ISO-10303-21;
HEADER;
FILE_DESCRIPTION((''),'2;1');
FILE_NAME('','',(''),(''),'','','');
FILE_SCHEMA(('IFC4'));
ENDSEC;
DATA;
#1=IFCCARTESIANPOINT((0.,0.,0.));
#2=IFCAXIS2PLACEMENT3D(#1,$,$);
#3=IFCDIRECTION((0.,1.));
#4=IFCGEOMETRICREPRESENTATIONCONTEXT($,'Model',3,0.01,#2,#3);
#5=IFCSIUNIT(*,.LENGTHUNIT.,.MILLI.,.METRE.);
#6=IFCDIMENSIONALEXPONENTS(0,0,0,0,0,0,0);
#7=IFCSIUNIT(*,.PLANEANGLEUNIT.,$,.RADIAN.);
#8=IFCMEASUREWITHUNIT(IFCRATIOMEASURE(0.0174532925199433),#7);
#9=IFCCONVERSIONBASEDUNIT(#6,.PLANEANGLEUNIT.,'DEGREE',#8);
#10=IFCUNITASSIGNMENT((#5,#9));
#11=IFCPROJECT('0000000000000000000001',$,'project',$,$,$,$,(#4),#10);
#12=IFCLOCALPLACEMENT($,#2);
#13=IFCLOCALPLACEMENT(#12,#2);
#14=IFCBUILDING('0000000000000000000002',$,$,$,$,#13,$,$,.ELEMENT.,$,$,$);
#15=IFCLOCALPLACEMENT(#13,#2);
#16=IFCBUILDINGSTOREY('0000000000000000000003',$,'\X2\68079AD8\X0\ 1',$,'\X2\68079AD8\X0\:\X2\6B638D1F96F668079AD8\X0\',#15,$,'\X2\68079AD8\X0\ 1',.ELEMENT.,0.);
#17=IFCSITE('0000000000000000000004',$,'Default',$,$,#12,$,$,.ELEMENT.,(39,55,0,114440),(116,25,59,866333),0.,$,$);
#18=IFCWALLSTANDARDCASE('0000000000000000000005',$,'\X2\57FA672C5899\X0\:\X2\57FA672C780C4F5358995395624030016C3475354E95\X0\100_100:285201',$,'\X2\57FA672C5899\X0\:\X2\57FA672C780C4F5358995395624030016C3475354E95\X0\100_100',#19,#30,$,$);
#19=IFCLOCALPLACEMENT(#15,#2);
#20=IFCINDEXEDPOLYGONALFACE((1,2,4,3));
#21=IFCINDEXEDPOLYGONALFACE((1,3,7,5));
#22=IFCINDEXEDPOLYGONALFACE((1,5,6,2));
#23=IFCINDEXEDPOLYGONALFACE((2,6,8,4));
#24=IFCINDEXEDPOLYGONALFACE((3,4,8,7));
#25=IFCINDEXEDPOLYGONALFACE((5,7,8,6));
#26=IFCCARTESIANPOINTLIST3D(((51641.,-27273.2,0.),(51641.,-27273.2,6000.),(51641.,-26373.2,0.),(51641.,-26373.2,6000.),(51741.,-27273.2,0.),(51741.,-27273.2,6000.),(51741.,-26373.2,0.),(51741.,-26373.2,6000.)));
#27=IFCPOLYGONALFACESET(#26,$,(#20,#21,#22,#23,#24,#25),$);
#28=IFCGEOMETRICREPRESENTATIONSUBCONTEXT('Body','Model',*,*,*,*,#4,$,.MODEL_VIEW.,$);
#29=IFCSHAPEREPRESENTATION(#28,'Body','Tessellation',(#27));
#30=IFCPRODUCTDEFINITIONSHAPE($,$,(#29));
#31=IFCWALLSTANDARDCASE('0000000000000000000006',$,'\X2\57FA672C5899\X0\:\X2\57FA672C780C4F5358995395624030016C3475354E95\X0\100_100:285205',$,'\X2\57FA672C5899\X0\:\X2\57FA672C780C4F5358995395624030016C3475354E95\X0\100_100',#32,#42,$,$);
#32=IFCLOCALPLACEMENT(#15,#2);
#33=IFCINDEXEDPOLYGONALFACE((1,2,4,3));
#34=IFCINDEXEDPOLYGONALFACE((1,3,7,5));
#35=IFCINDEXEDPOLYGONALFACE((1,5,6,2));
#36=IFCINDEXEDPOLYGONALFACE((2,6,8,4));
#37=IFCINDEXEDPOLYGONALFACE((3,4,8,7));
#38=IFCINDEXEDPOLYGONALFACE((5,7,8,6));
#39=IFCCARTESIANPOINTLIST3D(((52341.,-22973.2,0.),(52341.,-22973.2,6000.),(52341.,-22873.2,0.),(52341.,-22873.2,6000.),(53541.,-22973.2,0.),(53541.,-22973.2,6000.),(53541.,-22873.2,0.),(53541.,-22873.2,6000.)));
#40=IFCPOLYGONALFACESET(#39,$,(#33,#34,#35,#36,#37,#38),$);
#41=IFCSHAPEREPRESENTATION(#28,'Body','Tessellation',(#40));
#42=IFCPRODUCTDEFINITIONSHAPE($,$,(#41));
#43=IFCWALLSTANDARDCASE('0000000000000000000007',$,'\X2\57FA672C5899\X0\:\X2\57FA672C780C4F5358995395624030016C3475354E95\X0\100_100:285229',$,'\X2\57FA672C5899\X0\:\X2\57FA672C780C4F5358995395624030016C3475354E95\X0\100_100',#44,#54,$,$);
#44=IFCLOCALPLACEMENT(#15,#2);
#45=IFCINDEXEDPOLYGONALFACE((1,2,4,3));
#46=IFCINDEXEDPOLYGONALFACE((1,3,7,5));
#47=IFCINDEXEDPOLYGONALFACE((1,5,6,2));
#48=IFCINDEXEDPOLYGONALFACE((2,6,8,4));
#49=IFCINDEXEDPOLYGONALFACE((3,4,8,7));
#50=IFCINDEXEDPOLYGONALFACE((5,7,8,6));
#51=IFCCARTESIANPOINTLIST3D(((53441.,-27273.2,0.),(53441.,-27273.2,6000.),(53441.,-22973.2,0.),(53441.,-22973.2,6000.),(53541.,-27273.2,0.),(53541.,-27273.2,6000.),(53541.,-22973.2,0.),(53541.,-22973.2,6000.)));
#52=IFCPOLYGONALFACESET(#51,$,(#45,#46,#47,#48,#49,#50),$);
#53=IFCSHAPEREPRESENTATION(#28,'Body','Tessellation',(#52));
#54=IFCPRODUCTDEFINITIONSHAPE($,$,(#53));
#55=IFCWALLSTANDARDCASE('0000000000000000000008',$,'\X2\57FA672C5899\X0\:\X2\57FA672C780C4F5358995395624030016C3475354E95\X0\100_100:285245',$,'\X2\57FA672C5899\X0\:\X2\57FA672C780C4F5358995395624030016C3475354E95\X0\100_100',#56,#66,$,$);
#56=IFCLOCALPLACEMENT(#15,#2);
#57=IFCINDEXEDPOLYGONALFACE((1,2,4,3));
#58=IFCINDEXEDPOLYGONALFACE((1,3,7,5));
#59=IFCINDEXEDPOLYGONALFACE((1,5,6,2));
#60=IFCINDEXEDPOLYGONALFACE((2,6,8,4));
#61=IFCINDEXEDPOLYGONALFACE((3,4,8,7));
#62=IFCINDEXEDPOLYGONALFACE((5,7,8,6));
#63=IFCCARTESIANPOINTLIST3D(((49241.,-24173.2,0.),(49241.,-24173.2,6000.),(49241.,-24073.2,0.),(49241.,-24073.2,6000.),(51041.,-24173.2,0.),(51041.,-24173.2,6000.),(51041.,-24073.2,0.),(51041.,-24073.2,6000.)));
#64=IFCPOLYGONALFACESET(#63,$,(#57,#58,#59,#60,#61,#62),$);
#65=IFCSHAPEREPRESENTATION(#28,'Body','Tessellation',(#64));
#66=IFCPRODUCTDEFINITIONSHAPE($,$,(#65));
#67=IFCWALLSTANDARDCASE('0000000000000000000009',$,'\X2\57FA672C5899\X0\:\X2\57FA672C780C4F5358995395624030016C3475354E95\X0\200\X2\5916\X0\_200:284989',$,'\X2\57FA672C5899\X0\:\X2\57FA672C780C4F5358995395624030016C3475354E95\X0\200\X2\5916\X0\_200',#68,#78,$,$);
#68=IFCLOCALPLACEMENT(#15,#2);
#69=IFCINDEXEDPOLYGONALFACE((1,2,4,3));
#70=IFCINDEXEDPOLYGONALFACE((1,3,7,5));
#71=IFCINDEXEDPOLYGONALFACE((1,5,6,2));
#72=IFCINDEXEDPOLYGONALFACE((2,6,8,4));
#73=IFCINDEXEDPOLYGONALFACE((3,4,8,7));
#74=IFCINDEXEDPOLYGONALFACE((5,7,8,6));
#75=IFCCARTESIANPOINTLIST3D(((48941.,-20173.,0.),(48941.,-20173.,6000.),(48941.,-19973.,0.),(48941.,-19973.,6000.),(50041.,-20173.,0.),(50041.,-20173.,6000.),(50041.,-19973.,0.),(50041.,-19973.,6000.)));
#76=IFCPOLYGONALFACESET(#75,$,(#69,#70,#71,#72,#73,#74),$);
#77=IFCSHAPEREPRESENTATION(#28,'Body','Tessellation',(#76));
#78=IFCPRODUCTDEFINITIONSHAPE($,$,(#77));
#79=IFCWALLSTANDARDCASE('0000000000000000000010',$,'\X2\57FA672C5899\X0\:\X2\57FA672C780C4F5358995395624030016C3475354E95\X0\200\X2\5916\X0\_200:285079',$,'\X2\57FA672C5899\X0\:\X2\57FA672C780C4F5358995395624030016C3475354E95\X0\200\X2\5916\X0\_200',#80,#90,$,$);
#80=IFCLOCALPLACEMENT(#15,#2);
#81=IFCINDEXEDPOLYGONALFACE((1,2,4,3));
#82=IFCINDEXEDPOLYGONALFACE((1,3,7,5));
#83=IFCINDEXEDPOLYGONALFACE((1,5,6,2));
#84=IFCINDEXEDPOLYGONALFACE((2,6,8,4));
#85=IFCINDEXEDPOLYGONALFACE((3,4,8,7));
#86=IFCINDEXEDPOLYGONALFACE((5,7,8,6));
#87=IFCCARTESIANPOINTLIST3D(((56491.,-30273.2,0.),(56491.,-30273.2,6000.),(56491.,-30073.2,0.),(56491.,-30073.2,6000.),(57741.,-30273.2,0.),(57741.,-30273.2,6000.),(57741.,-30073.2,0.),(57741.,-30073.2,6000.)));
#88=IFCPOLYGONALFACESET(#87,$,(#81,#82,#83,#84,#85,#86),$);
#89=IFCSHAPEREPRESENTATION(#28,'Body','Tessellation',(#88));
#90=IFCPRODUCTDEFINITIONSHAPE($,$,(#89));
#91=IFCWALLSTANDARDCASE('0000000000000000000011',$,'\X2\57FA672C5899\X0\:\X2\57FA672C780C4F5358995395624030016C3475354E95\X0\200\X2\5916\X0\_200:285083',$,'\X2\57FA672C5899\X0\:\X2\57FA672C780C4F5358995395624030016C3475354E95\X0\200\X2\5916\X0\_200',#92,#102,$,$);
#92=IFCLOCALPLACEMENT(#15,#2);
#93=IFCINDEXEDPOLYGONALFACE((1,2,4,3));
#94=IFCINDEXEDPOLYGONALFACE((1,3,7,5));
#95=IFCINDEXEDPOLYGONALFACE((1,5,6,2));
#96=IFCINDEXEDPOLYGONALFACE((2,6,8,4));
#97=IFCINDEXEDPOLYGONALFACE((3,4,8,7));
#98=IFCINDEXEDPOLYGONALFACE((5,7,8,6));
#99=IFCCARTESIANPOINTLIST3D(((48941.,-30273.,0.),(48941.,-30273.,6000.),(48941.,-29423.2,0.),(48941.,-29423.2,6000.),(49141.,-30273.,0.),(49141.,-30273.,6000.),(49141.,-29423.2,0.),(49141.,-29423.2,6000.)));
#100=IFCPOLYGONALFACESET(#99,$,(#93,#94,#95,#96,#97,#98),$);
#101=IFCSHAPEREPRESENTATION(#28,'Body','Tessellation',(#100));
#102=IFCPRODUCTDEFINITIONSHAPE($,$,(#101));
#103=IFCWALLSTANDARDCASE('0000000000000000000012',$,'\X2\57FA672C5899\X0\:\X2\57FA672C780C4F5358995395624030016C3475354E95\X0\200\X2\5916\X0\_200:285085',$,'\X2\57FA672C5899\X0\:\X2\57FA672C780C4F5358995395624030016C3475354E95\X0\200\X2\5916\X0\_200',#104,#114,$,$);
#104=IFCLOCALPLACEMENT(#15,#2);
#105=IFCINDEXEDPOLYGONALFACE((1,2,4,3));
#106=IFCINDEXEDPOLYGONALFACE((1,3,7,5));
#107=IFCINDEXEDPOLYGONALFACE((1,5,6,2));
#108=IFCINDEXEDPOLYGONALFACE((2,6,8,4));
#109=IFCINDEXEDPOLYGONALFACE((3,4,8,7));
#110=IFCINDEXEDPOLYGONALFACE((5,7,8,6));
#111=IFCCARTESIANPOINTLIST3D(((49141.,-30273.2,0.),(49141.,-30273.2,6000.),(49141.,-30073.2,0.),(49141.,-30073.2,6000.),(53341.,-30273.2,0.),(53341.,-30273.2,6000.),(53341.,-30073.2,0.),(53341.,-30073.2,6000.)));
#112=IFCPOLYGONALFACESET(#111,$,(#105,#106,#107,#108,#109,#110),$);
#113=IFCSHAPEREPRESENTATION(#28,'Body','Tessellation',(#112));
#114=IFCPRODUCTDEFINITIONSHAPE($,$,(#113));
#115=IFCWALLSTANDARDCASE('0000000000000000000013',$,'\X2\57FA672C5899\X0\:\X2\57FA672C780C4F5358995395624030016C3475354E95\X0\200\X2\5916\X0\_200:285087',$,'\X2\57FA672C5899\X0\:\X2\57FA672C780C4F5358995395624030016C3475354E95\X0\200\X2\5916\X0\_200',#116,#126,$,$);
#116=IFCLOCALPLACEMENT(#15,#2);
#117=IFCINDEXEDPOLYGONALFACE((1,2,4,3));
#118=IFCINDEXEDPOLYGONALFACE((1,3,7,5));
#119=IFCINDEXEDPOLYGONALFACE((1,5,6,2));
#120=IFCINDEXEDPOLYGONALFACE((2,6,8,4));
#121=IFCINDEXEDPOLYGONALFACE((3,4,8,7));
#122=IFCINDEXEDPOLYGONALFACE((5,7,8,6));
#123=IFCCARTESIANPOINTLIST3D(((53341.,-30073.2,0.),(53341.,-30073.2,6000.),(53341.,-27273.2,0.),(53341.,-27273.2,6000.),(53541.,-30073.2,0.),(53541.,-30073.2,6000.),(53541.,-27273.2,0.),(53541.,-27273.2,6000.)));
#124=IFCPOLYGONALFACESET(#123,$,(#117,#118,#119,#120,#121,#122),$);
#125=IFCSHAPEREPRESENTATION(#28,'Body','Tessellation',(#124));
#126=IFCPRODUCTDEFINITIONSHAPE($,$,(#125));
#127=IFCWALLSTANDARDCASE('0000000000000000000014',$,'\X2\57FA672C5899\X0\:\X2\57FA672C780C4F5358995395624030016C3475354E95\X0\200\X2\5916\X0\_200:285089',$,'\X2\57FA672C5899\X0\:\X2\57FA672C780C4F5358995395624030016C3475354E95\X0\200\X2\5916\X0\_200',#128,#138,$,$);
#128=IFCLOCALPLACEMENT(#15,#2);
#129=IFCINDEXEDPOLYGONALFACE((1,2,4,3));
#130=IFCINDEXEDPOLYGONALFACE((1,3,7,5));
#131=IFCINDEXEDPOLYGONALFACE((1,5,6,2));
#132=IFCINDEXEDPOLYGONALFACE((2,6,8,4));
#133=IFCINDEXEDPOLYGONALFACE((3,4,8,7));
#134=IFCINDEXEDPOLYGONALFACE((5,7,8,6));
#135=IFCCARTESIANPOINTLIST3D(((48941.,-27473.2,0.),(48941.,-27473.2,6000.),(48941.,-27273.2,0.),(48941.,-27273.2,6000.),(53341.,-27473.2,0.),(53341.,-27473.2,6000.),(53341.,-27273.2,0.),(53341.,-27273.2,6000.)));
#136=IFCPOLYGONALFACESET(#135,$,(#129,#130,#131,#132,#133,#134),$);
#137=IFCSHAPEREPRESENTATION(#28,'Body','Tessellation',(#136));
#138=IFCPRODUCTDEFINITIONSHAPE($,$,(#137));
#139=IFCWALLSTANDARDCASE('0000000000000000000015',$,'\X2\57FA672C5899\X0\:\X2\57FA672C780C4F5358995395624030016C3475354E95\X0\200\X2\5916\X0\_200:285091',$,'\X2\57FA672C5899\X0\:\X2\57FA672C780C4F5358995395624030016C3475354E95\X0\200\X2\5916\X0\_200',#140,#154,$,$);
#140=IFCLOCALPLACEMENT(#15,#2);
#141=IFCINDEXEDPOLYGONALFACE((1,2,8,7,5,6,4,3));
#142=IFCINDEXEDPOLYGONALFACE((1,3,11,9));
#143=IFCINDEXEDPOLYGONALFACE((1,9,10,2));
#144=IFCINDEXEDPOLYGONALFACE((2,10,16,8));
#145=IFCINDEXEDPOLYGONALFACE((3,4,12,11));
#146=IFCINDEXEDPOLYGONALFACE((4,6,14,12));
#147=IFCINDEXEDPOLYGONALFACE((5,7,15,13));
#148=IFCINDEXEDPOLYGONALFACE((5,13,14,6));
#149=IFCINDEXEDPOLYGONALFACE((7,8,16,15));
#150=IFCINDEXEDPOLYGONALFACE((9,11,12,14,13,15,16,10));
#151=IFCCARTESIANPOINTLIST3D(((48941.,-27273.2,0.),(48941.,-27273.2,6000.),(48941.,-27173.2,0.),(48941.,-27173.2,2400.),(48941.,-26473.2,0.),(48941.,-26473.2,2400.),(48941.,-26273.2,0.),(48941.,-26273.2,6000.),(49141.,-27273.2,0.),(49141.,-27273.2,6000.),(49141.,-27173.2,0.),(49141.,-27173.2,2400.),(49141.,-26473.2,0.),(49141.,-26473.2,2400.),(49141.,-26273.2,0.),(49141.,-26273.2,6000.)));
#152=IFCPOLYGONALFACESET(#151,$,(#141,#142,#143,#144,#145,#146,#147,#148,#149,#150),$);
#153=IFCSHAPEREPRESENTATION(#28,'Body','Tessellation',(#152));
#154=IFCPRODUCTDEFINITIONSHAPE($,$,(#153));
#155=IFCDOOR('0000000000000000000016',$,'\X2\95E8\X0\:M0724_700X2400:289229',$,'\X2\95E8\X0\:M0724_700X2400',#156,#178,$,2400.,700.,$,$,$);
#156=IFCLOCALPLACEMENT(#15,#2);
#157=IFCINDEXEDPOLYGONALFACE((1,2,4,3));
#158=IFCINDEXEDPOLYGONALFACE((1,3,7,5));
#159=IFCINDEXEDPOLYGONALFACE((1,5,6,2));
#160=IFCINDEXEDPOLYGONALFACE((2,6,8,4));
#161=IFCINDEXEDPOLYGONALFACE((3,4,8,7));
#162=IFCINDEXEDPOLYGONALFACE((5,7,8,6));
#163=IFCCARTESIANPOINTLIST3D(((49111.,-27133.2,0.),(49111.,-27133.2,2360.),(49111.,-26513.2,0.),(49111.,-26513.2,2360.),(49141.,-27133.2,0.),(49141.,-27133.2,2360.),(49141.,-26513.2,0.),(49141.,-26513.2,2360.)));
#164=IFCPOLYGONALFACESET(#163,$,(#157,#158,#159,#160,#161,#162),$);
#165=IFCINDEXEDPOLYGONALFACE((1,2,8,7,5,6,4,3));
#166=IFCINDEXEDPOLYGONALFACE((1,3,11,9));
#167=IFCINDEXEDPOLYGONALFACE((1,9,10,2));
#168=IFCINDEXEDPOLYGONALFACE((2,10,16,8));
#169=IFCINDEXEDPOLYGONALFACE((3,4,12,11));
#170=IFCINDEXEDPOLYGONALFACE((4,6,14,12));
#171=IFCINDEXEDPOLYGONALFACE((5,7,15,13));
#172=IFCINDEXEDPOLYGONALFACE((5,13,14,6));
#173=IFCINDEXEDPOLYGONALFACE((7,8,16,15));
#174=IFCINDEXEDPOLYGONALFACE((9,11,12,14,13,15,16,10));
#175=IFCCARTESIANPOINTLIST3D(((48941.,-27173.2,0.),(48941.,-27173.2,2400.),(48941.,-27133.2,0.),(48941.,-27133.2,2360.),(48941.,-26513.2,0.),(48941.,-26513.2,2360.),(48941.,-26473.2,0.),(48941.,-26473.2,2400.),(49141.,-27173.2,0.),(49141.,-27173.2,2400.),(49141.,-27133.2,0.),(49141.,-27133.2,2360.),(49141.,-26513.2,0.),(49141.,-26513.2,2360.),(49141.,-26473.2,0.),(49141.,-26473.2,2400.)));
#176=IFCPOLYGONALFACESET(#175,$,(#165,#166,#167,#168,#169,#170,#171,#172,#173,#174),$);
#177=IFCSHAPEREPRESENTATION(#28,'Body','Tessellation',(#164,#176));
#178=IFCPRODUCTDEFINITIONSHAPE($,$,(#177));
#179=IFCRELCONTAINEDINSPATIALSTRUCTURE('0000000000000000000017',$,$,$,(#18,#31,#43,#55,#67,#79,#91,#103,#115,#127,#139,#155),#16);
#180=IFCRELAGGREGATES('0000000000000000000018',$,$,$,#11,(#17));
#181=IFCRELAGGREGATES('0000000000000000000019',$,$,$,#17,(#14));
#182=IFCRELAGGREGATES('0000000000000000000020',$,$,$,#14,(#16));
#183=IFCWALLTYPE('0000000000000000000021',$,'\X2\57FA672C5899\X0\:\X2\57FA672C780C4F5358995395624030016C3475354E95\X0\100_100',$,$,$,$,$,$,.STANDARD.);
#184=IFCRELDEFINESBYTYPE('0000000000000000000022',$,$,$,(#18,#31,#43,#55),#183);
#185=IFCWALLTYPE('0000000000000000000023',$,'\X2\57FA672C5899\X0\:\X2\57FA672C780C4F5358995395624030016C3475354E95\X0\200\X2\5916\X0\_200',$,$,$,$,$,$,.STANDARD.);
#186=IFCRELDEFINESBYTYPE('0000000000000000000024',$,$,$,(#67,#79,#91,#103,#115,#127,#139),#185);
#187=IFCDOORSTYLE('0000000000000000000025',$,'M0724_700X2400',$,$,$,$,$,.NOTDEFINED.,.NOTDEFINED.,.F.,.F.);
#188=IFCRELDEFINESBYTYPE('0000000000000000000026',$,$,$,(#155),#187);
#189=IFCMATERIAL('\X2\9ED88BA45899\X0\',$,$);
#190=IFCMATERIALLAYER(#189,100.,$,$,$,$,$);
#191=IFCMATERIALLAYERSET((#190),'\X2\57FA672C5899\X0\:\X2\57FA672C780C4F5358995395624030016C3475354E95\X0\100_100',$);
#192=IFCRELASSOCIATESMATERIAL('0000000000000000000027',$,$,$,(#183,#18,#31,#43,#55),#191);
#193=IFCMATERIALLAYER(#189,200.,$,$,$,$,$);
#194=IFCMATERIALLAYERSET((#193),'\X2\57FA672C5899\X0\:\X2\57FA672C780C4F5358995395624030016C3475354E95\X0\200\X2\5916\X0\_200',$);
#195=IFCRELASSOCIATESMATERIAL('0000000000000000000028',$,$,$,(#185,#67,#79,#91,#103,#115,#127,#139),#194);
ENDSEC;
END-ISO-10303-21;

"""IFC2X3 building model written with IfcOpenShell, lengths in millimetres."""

from ifc_helpers import new_model, entity, si_unit, converted_unit, direction, frame, frame_2d, origin, place, context, subcontext, project, spatial, polyline, rectangle, outline, extrude, source, transform, mapped, material, layer, layer_set, layer_usage, type_object, type_shapes, element, fill, save


model = new_model("IFC2X3")

# Units and contexts
model_context = context("Model", 3, precision=0.01, world=origin(), true_north=direction((0.0, 1.0)))
body_context = subcontext(model_context, "Body", "Model", "MODEL_VIEW")
ifc_project = project(units=[si_unit("LENGTHUNIT", "METRE", prefix="MILLI"), converted_unit("PLANEANGLEUNIT", "DEGREE", entity("IfcRatioMeasure", 0.0174532925199433), si_unit("PLANEANGLEUNIT", "RADIAN"), dimensions=[0, 0, 0, 0, 0, 0, 0])], contexts=[model_context])

# Site, building, storey
site_placement = place(None, origin())
site = spatial("IfcSite", under=ifc_project, at=site_placement, Name="Default", CompositionType="ELEMENT", RefLatitude=(39, 55, 0, 114440), RefLongitude=(116, 25, 59, 866333), RefElevation=0.0)
building_placement = place(site_placement, origin())
building = spatial("IfcBuilding", under=site, at=building_placement, CompositionType="ELEMENT")
storey_placement = place(building_placement, origin())
storey = spatial("IfcBuildingStorey", under=building, at=storey_placement, Name="标高 1", ObjectType="标高:正负零标高", LongName="标高 1", CompositionType="ELEMENT", Elevation=0.0)

# Walls
ifc_material = material(Name="默认墙")
ifc_layer_1 = layer(ifc_material, 100.0)
ifc_layer_set_1 = layer_set([ifc_layer_1], Name="基本墙:基本砌体墙厕所、水电井100_100")
wall_type_1 = type_object("IfcWallType", Name="基本墙:基本砌体墙厕所、水电井100_100", PredefinedType="STANDARD", material=ifc_layer_set_1)
ifc_layer_usage_1 = layer_usage(ifc_layer_set_1, "AXIS2", "NEGATIVE", 50.0)
wall_1_placement = place(building_placement, frame((51691.0, -26373.2, 0.0), z_axis=(0.0, 0.0, 1.0), x_axis=(0.0, -1.0, 0.0)))
element("IfcWallStandardCase", 1, at=wall_1_placement, inside=storey, type_object=wall_type_1, material=ifc_layer_usage_1, Name="基本墙:基本砌体墙厕所、水电井100_100:285201", ObjectType="基本墙:基本砌体墙厕所、水电井100_100", context=body_context, shape_type="SweptSolid", body=[
    extrude(rectangle(XDim=900.0, YDim=100.0, at=frame_2d((450.0, 0.0), x_axis=(-1.0, 0.0))), origin(), (0.0, 0.0, 1.0), 6000.0),
])
ifc_layer_usage_2 = layer_usage(ifc_layer_set_1, "AXIS2", "NEGATIVE", 50.0)
wall_2_placement = place(building_placement, frame((52341.0, -22923.2, 0.0)))
element("IfcWallStandardCase", 2, at=wall_2_placement, inside=storey, type_object=wall_type_1, material=ifc_layer_usage_2, Name="基本墙:基本砌体墙厕所、水电井100_100:285205", ObjectType="基本墙:基本砌体墙厕所、水电井100_100", context=body_context, shape_type="SweptSolid", body=[
    extrude(rectangle(XDim=1200.0, YDim=100.0, at=frame_2d((600.0, 0.0), x_axis=(-1.0, 0.0))), origin(), (0.0, 0.0, 1.0), 6000.0),
])
ifc_layer_usage_3 = layer_usage(ifc_layer_set_1, "AXIS2", "NEGATIVE", 50.0)
wall_3_placement = place(building_placement, frame((53491.0, -27273.2, 0.0), z_axis=(0.0, 0.0, 1.0), x_axis=(0.0, 1.0, 0.0)))
element("IfcWallStandardCase", 3, at=wall_3_placement, inside=storey, type_object=wall_type_1, material=ifc_layer_usage_3, Name="基本墙:基本砌体墙厕所、水电井100_100:285229", ObjectType="基本墙:基本砌体墙厕所、水电井100_100", context=body_context, shape_type="SweptSolid", body=[
    extrude(rectangle(XDim=4300.0, YDim=100.0, at=frame_2d((2150.0, 0.0), x_axis=(-1.0, 0.0))), origin(), (0.0, 0.0, 1.0), 6000.0),
])
ifc_layer_usage_4 = layer_usage(ifc_layer_set_1, "AXIS2", "NEGATIVE", 50.0)
wall_4_placement = place(building_placement, frame((51041.0, -24123.2, 0.0), z_axis=(0.0, 0.0, 1.0), x_axis=(-1.0, 0.0, 0.0)))
element("IfcWallStandardCase", 4, at=wall_4_placement, inside=storey, type_object=wall_type_1, material=ifc_layer_usage_4, Name="基本墙:基本砌体墙厕所、水电井100_100:285245", ObjectType="基本墙:基本砌体墙厕所、水电井100_100", context=body_context, shape_type="SweptSolid", body=[
    extrude(rectangle(XDim=1800.0, YDim=100.0, at=frame_2d((900.0, 0.0), x_axis=(-1.0, 0.0))), origin(), (0.0, 0.0, 1.0), 6000.0),
])
ifc_layer_2 = layer(ifc_material, 200.0)
ifc_layer_set_2 = layer_set([ifc_layer_2], Name="基本墙:基本砌体墙厕所、水电井200外_200")
ifc_layer_usage_5 = layer_usage(ifc_layer_set_2, "AXIS2", "NEGATIVE", 100.0)
wall_type_2 = type_object("IfcWallType", Name="基本墙:基本砌体墙厕所、水电井200外_200", PredefinedType="STANDARD", material=ifc_layer_set_2)
wall_5_placement = place(building_placement, frame((48941.0, -20073.0, 0.0)))
element("IfcWallStandardCase", 5, at=wall_5_placement, inside=storey, type_object=wall_type_2, material=ifc_layer_usage_5, Name="基本墙:基本砌体墙厕所、水电井200外_200:284989", ObjectType="基本墙:基本砌体墙厕所、水电井200外_200", context=body_context, shape_type="SweptSolid", body=[
    extrude(rectangle(XDim=1100.0, YDim=200.0, at=frame_2d((550.0, 0.0), x_axis=(-1.0, 0.0))), origin(), (0.0, 0.0, 1.0), 6000.0),
])
ifc_layer_usage_6 = layer_usage(ifc_layer_set_2, "AXIS2", "NEGATIVE", 100.0)
wall_6_placement = place(building_placement, frame((56491.0, -30173.2, 0.0)))
element("IfcWallStandardCase", 6, at=wall_6_placement, inside=storey, type_object=wall_type_2, material=ifc_layer_usage_6, Name="基本墙:基本砌体墙厕所、水电井200外_200:285079", ObjectType="基本墙:基本砌体墙厕所、水电井200外_200", context=body_context, shape_type="SweptSolid", body=[
    extrude(rectangle(XDim=1250.0, YDim=200.0, at=frame_2d((625.0, 0.0), x_axis=(-1.0, 0.0))), origin(), (0.0, 0.0, 1.0), 6000.0),
])
ifc_layer_usage_7 = layer_usage(ifc_layer_set_2, "AXIS2", "NEGATIVE", 100.0)
wall_7_placement = place(building_placement, frame((49041.0, -30273.0, 0.0), z_axis=(0.0, 0.0, 1.0), x_axis=(0.0, 1.0, 0.0)))
element("IfcWallStandardCase", 7, at=wall_7_placement, inside=storey, type_object=wall_type_2, material=ifc_layer_usage_7, Name="基本墙:基本砌体墙厕所、水电井200外_200:285083", ObjectType="基本墙:基本砌体墙厕所、水电井200外_200", context=body_context, shape_type="SweptSolid", body=[
    extrude(rectangle(XDim=849.8, YDim=200.0, at=frame_2d((424.9, 0.0), x_axis=(-1.0, 0.0))), origin(), (0.0, 0.0, 1.0), 6000.0),
])
ifc_layer_usage_8 = layer_usage(ifc_layer_set_2, "AXIS2", "NEGATIVE", 100.0)
wall_8_placement = place(building_placement, frame((53341.0, -30173.2, 0.0), z_axis=(0.0, 0.0, 1.0), x_axis=(-1.0, 0.0, 0.0)))
element("IfcWallStandardCase", 8, at=wall_8_placement, inside=storey, type_object=wall_type_2, material=ifc_layer_usage_8, Name="基本墙:基本砌体墙厕所、水电井200外_200:285085", ObjectType="基本墙:基本砌体墙厕所、水电井200外_200", context=body_context, shape_type="SweptSolid", body=[
    extrude(rectangle(XDim=4200.0, YDim=200.0, at=frame_2d((2100.0, 0.0), x_axis=(-1.0, 0.0))), origin(), (0.0, 0.0, 1.0), 6000.0),
])
ifc_layer_usage_9 = layer_usage(ifc_layer_set_2, "AXIS2", "NEGATIVE", 100.0)
wall_9_placement = place(building_placement, frame((53441.0, -27273.2, 0.0), z_axis=(0.0, 0.0, 1.0), x_axis=(0.0, -1.0, 0.0)))
element("IfcWallStandardCase", 9, at=wall_9_placement, inside=storey, type_object=wall_type_2, material=ifc_layer_usage_9, Name="基本墙:基本砌体墙厕所、水电井200外_200:285087", ObjectType="基本墙:基本砌体墙厕所、水电井200外_200", context=body_context, shape_type="SweptSolid", body=[
    extrude(rectangle(XDim=2800.0, YDim=200.0, at=frame_2d((1400.0, 0.0), x_axis=(-1.0, 0.0))), origin(), (0.0, 0.0, 1.0), 6000.0),
])
ifc_layer_usage_10 = layer_usage(ifc_layer_set_2, "AXIS2", "NEGATIVE", 100.0)
wall_10_placement = place(building_placement, frame((48941.0, -27373.2, 0.0)))
element("IfcWallStandardCase", 10, at=wall_10_placement, inside=storey, type_object=wall_type_2, material=ifc_layer_usage_10, Name="基本墙:基本砌体墙厕所、水电井200外_200:285089", ObjectType="基本墙:基本砌体墙厕所、水电井200外_200", context=body_context, shape_type="SweptSolid", body=[
    extrude(rectangle(XDim=4400.0, YDim=200.0, at=frame_2d((2200.0, 0.0), x_axis=(-1.0, 0.0))), origin(), (0.0, 0.0, 1.0), 6000.0),
])

# Wall, opening, door
ifc_layer_usage_11 = layer_usage(ifc_layer_set_2, "AXIS2", "NEGATIVE", 100.0)
wall_11_placement = place(building_placement, frame((49041.0, -26273.2, 0.0), z_axis=(0.0, 0.0, 1.0), x_axis=(0.0, -1.0, 0.0)))
wall_11 = element("IfcWallStandardCase", 11, at=wall_11_placement, inside=storey, type_object=wall_type_2, material=ifc_layer_usage_11, Name="基本墙:基本砌体墙厕所、水电井200外_200:285091", ObjectType="基本墙:基本砌体墙厕所、水电井200外_200", context=body_context, shape_type="SweptSolid", body=[
    extrude(rectangle(XDim=1000.0, YDim=200.0, at=frame_2d((500.0, 0.0), x_axis=(-1.0, 0.0))), origin(), (0.0, 0.0, 1.0), 6000.0),
])
opening_1_placement = place(wall_11_placement, frame((200.0, -100.0, 0.0)))
opening_1 = element("IfcOpeningElement", 12, at=opening_1_placement, cuts=wall_11, ObjectType="Opening", context=body_context, shape_type="SweptSolid", body=[
    extrude(rectangle(XDim=2400.0, YDim=700.0, at=frame_2d((1200.0, 350.0), x_axis=(1.0, 0.0))), frame((0.0, 0.0, 0.0), z_axis=(0.0, 1.0, 0.0), x_axis=(0.0, 0.0, 1.0)), (0.0, 0.0, 1.0), 200.0),
])
door_style_1 = type_object("IfcDoorStyle", Name="M0724_700X2400", ConstructionType="NOTDEFINED", OperationType="NOTDEFINED", ParameterTakesPrecedence=False, Sizeable=False)
shared_shape_1 = source(origin(), body_context, "Body", "SweptSolid", [
    extrude(rectangle(XDim=30.0, YDim=620.0, at=frame_2d((0.0, 0.0), x_axis=(1.0, 0.0))), frame((350.0, -715.0, 0.0), z_axis=(0.0, 0.0, 1.0), x_axis=(0.0, 1.0, 0.0)), (0.0, 0.0, 1.0), 2360.0),
    extrude(outline(polyline([(-1170.0, 310.0), (1190.0, 310.0), (1190.0, 350.0), (-1210.0, 350.0), (-1210.0, -350.0), (1190.0, -350.0), (1190.0, -310.0), (-1170.0, -310.0), (-1170.0, 310.0)])), frame((350.0, -900.0, 1190.0), z_axis=(0.0, 1.0, 0.0), x_axis=(0.0, 0.0, -1.0)), (0.0, 0.0, 1.0), 200.0),
])
type_shapes(door_style_1, [shared_shape_1])
door_1_placement = place(opening_1_placement, frame((0.0, 900.0, 0.0)))
door_1 = element("IfcDoor", 13, at=door_1_placement, inside=storey, type_object=door_style_1, Name="门:M0724_700X2400:289229", ObjectType="门:M0724_700X2400", OverallHeight=2400.0, OverallWidth=700.0, context=body_context, shape_type="MappedRepresentation", body=[
    mapped(shared_shape_1, transform((0.0, 0.0, 0.0), scale=1.0)),
])
fill(opening_1, door_1)

save(model, "model.ifc")
